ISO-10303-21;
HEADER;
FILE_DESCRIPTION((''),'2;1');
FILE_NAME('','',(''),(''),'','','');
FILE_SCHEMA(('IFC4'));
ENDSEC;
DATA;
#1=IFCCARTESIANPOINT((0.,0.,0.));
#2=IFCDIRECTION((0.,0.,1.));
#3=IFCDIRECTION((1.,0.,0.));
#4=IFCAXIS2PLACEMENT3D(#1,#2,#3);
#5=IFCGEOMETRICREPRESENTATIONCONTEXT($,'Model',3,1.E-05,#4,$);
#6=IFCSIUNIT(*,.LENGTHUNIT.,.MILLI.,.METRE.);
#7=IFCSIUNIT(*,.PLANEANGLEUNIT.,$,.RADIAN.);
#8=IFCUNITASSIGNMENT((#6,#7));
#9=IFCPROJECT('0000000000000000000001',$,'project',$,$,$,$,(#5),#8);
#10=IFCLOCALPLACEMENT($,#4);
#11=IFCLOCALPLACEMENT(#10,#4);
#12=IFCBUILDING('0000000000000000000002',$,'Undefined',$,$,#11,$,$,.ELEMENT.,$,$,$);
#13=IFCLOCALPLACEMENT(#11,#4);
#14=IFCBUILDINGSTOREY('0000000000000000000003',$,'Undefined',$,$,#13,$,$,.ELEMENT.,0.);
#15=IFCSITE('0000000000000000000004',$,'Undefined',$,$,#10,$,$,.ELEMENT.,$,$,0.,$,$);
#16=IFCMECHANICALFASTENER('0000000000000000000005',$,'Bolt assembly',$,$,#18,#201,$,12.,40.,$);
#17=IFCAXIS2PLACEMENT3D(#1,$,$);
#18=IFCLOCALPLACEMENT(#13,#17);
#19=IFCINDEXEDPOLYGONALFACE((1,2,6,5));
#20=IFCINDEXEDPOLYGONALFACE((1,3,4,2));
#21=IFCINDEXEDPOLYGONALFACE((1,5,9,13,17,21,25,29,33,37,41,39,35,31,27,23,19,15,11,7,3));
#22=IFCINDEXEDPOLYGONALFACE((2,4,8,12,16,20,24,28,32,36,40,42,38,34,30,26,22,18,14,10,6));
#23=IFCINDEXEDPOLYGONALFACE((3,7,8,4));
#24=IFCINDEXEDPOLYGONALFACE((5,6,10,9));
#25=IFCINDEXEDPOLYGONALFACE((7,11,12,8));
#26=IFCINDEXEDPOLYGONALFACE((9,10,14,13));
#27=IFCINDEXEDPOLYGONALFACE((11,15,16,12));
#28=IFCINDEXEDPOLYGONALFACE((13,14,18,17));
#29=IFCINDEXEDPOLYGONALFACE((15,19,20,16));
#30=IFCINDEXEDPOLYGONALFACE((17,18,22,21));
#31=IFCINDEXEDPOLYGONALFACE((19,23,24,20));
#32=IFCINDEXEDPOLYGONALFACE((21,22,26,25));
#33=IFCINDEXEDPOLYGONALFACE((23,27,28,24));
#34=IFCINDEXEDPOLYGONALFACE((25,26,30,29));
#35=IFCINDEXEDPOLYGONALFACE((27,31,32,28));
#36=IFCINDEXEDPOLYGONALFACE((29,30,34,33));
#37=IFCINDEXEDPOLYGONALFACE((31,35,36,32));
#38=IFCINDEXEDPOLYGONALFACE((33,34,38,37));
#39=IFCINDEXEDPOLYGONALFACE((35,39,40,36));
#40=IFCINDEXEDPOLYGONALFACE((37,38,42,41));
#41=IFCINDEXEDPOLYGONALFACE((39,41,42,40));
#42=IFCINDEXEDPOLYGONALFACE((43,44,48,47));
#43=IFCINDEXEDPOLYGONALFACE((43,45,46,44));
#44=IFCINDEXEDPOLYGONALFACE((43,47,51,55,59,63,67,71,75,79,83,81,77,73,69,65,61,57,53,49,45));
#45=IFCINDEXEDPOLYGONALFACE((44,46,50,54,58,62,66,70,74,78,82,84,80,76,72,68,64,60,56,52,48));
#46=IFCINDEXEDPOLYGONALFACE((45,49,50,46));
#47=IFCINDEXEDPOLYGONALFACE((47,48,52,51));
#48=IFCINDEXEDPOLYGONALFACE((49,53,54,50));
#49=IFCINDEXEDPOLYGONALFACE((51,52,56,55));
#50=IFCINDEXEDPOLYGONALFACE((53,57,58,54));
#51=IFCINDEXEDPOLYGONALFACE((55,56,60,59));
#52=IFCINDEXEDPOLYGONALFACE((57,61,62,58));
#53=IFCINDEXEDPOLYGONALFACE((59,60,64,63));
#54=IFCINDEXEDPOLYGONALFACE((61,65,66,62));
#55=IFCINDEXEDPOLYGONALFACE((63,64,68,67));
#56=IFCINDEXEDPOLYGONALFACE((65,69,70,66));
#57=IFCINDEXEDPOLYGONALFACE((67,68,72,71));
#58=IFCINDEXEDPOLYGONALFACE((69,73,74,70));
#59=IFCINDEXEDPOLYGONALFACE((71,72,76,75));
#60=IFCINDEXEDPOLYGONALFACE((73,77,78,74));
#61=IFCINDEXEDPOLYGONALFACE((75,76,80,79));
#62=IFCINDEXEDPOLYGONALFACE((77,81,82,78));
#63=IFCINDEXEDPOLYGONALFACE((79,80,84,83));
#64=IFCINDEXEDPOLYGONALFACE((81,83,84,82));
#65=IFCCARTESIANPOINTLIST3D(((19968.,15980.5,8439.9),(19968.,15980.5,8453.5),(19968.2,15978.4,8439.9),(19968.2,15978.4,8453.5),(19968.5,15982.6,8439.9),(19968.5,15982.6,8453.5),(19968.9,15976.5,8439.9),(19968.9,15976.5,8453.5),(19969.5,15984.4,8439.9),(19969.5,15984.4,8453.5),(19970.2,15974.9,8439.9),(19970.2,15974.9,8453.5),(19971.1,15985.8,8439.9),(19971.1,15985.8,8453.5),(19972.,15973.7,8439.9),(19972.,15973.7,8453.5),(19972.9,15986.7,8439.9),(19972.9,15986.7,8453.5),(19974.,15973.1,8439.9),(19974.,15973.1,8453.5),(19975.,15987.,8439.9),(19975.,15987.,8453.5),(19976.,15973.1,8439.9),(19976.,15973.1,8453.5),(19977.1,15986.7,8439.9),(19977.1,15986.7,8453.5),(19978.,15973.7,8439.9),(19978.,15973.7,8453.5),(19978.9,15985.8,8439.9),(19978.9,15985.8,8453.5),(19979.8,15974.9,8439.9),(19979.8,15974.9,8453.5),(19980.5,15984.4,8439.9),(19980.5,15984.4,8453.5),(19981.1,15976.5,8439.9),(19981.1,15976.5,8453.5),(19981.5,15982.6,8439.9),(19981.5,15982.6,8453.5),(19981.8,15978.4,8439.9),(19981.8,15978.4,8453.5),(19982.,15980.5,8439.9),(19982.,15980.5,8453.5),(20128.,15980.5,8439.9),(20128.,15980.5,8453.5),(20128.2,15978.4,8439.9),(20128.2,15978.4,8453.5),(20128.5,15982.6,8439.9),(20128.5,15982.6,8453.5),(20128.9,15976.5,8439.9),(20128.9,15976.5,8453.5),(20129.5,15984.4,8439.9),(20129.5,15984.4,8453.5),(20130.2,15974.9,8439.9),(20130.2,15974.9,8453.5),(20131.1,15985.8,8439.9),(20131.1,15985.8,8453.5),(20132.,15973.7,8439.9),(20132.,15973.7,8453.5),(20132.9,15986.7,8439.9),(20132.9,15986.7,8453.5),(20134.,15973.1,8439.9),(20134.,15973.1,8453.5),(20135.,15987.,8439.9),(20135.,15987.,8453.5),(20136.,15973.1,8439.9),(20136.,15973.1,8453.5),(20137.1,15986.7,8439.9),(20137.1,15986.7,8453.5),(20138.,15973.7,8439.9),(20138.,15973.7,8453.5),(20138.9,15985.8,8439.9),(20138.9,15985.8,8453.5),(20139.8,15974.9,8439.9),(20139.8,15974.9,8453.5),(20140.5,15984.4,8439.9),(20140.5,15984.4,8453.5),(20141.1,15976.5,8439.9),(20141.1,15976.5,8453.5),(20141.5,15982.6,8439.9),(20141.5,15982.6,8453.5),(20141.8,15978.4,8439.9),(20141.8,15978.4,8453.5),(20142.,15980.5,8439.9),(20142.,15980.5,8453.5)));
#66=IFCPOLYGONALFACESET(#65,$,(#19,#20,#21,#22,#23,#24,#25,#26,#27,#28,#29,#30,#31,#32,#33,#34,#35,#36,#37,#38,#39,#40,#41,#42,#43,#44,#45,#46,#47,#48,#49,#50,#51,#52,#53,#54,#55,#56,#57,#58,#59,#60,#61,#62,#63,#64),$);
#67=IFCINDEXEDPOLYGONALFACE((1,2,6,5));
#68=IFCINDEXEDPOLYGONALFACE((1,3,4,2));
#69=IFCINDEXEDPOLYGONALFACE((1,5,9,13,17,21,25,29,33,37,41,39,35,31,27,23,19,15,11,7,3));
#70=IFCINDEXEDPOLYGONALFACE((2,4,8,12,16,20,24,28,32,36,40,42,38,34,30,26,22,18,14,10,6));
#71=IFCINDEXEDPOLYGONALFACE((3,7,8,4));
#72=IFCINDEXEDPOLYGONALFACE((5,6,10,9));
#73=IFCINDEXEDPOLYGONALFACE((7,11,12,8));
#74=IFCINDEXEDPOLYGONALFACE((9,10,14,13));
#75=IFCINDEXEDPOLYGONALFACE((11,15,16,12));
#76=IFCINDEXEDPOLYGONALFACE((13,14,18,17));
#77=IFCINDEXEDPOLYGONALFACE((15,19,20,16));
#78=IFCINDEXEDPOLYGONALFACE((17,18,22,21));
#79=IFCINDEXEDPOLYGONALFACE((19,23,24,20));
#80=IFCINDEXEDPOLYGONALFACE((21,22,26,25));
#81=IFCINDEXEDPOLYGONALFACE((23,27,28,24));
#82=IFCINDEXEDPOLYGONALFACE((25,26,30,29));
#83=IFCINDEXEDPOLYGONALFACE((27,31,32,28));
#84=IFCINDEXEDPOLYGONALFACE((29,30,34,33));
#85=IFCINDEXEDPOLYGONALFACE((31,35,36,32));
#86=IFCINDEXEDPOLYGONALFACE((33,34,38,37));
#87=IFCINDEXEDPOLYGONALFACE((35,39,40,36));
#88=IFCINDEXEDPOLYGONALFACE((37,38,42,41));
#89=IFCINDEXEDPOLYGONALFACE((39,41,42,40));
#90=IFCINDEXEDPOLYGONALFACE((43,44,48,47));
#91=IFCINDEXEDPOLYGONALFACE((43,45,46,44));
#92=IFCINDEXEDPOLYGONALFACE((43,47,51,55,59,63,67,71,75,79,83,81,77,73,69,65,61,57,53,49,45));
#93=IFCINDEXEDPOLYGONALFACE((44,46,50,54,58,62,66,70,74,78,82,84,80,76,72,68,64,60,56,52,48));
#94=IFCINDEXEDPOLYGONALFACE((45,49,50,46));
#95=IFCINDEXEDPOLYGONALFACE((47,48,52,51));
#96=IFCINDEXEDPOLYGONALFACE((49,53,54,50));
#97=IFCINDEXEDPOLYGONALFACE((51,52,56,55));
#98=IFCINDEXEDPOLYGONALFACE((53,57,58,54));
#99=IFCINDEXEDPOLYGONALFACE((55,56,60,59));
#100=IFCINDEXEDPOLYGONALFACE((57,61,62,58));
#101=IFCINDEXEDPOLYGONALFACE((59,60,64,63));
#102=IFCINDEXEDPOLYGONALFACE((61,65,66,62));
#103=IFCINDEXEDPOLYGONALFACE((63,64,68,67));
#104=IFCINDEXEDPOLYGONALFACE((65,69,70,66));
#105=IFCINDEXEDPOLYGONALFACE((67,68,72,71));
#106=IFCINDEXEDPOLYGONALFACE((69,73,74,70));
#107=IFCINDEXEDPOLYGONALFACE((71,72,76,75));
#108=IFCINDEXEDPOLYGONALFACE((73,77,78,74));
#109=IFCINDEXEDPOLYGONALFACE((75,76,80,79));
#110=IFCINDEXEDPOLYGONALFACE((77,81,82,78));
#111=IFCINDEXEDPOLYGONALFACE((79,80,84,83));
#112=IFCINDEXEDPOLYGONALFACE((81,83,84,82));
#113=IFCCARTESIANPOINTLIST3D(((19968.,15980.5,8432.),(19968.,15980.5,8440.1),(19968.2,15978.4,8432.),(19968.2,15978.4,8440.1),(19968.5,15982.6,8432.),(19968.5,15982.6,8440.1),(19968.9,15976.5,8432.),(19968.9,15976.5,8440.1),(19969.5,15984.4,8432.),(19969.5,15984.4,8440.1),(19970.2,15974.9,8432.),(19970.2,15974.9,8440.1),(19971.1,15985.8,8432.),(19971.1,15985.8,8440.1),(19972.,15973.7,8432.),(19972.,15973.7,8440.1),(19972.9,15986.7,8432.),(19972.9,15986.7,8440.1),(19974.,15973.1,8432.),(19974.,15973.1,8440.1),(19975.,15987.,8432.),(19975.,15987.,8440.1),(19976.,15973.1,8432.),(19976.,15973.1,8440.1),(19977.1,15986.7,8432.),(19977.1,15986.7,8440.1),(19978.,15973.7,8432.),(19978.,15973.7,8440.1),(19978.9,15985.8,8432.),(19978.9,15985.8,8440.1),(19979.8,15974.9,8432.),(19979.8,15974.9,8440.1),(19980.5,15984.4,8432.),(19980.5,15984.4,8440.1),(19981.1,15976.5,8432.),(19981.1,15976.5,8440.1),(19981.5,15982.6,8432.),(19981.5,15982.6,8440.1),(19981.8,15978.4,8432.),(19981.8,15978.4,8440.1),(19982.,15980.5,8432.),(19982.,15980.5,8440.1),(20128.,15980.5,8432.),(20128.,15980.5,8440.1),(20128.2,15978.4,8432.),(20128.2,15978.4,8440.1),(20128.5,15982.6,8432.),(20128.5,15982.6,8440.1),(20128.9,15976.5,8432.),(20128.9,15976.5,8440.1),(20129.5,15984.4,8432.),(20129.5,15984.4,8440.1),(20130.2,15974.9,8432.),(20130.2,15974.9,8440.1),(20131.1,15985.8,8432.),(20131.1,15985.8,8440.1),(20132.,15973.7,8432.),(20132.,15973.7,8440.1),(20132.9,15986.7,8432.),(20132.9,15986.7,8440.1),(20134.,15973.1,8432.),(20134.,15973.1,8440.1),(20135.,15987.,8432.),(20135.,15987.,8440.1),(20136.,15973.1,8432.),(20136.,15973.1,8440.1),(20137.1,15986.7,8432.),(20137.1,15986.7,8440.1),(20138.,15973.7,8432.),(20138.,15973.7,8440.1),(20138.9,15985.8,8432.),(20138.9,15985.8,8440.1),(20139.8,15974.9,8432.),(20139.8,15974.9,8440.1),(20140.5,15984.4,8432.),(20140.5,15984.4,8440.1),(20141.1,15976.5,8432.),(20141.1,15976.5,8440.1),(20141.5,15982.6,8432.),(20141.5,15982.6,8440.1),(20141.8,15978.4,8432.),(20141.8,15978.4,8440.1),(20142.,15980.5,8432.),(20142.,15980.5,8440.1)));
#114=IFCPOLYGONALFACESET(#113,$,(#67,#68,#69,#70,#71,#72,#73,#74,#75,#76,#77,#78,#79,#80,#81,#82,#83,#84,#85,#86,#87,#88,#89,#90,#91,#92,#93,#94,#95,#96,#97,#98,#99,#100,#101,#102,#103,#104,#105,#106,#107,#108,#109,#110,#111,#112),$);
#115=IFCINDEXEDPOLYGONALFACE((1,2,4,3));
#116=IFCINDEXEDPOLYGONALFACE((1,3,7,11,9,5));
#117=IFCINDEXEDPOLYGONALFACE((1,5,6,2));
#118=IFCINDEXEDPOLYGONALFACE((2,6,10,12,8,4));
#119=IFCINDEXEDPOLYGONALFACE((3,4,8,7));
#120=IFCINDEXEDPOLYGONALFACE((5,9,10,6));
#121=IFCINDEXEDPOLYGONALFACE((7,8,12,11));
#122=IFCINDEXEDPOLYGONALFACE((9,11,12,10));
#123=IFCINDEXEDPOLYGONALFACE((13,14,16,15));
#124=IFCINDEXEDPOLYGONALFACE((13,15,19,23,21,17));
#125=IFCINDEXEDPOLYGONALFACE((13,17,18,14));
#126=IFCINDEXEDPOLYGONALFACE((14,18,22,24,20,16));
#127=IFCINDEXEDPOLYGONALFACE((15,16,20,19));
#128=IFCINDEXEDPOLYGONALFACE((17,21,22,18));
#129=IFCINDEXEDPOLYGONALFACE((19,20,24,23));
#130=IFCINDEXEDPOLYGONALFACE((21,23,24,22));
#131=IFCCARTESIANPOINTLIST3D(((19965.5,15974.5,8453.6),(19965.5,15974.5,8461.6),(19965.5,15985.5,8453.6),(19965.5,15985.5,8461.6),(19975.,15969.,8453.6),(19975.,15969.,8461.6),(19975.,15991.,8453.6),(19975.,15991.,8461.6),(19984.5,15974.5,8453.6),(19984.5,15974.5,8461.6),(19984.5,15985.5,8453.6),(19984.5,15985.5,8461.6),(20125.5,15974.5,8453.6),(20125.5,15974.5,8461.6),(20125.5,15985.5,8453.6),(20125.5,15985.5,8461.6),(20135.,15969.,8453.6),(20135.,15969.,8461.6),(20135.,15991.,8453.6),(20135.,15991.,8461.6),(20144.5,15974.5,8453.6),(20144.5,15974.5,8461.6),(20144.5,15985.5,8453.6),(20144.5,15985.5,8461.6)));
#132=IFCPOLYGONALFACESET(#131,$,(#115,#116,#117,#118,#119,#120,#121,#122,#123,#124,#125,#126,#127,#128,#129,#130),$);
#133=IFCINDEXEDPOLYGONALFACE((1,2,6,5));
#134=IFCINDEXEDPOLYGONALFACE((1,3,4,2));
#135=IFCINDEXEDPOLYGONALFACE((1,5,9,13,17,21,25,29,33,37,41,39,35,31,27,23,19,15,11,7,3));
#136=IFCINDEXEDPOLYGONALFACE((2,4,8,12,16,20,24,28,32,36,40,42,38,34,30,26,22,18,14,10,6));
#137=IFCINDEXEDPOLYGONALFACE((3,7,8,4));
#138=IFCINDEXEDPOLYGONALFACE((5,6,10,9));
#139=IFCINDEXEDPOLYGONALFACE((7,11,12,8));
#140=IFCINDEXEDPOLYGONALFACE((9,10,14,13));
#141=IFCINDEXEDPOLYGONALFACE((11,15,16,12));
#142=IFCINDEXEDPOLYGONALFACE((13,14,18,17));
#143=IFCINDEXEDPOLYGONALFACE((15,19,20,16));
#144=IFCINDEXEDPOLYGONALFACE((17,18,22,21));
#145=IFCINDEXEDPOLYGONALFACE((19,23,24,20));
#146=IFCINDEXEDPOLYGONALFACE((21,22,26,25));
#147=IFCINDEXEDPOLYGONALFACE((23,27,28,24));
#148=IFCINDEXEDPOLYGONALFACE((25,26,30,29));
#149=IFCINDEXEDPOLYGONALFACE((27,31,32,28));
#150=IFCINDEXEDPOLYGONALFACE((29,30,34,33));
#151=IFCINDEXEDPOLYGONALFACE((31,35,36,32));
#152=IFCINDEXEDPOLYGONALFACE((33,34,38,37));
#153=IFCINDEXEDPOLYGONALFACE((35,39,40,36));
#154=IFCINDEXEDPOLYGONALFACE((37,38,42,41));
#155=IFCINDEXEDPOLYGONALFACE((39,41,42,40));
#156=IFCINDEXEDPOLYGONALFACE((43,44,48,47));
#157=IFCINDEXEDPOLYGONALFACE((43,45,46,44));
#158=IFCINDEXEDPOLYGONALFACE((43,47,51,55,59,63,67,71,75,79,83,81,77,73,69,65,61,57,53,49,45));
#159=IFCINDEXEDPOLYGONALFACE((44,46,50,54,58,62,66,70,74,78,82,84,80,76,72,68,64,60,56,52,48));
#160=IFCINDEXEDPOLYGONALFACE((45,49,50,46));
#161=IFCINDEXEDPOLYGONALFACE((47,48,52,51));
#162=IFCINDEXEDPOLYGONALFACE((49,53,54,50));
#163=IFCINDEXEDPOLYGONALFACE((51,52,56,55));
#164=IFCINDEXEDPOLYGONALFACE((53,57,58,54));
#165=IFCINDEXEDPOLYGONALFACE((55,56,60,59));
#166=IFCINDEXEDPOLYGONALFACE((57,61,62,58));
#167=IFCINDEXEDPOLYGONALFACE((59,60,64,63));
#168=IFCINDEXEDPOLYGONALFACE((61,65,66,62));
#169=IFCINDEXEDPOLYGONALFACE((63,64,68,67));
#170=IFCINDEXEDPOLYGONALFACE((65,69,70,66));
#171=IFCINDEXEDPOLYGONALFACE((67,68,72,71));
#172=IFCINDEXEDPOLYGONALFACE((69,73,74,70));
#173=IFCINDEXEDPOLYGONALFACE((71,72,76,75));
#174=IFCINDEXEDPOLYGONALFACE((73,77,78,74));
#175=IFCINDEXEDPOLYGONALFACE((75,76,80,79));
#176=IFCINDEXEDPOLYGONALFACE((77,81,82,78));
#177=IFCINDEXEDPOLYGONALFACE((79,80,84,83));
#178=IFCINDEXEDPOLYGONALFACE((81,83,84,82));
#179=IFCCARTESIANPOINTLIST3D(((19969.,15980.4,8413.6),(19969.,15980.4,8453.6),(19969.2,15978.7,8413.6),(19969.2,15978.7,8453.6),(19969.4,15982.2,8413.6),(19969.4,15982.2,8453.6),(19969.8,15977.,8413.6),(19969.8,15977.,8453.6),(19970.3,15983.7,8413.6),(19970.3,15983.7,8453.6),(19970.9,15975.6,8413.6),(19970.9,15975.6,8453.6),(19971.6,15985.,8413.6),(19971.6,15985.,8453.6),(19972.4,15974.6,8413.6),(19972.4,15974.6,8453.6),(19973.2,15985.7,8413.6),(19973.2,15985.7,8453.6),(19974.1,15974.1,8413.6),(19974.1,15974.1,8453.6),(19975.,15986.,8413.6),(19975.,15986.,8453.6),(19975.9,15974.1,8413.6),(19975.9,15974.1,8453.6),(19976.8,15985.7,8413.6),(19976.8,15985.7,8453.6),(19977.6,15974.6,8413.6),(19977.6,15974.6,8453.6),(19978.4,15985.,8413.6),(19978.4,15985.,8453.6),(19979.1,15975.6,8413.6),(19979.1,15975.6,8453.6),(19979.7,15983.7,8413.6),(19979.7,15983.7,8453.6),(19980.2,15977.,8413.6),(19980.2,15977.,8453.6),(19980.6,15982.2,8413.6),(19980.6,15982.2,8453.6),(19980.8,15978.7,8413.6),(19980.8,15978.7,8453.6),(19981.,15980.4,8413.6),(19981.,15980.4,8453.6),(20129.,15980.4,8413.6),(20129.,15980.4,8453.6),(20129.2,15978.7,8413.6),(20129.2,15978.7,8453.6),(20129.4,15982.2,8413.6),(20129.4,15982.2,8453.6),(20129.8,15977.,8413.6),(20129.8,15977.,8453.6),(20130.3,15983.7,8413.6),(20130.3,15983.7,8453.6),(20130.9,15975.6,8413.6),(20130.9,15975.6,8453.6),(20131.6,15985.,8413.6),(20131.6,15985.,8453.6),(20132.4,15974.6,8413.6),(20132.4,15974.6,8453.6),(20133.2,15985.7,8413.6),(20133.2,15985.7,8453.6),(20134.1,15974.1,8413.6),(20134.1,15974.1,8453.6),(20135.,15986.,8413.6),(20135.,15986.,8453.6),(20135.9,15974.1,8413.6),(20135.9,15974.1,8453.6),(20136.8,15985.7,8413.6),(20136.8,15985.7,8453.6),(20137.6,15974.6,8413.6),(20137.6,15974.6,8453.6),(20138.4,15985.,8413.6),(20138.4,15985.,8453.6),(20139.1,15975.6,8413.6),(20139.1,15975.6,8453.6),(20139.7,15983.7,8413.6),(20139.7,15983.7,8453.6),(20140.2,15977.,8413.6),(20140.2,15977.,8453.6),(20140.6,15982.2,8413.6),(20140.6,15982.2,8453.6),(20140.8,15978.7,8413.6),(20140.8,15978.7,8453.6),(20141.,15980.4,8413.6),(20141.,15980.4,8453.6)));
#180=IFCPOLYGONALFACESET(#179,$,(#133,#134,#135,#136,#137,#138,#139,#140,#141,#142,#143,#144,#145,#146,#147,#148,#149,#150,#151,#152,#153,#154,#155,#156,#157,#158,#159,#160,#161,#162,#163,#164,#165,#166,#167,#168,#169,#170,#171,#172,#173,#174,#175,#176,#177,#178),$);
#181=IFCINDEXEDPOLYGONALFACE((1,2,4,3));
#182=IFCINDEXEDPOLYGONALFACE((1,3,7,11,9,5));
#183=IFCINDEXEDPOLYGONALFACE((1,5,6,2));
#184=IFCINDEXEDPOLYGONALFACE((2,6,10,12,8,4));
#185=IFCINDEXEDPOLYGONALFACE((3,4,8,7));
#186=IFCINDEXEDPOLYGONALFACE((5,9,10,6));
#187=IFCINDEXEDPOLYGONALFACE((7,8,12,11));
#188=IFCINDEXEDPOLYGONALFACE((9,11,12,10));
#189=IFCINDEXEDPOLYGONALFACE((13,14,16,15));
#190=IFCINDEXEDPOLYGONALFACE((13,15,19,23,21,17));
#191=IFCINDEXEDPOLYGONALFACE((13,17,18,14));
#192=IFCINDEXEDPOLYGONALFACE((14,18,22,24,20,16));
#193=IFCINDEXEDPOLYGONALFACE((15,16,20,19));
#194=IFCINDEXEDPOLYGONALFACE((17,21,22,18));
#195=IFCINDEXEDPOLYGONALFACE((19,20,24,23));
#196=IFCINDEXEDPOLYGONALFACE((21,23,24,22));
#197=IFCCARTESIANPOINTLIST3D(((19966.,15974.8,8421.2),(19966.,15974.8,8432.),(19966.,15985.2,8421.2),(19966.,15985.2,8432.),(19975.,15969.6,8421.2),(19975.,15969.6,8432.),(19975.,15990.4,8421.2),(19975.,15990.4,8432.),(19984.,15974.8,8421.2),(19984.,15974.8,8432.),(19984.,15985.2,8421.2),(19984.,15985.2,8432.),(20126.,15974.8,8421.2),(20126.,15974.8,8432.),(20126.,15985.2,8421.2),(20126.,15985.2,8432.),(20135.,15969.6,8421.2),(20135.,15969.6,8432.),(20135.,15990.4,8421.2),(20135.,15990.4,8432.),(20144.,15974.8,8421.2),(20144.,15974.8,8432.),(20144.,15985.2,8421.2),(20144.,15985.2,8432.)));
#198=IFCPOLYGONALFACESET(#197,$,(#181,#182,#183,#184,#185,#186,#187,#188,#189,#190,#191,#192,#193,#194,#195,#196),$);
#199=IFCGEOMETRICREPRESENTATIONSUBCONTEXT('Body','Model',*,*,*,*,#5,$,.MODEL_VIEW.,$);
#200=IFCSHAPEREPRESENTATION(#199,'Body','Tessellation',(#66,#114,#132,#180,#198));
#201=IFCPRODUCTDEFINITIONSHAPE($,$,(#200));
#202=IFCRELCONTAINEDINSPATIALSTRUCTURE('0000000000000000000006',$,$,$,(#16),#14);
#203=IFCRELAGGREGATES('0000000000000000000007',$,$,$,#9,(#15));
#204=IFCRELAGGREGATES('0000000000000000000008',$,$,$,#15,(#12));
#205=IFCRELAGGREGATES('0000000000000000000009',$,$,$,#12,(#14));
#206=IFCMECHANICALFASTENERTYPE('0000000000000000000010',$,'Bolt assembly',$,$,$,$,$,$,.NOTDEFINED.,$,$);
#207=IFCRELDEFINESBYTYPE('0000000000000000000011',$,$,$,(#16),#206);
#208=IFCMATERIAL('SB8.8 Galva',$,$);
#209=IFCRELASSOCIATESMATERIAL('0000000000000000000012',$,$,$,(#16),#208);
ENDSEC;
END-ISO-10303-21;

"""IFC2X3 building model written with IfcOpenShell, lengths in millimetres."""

from ifc_helpers import new_model, si_unit, frame, origin_with_axes, origin_2d_with_axis, place, context, subcontext, project, spatial, polyline, circle, outline, extrude, source, transform, mapped, material, type_object, element, save


model = new_model("IFC2X3")

# Units and contexts
model_context = context("Model", 3, precision=1e-05, world=origin_with_axes())
body_context = subcontext(model_context, "Body", "Model", "MODEL_VIEW")
ifc_project = project(units=[si_unit("LENGTHUNIT", "METRE", prefix="MILLI"), si_unit("PLANEANGLEUNIT", "RADIAN")], contexts=[model_context])

# Site, building, storey
site_placement = place(None, origin_with_axes())
site = spatial("IfcSite", under=ifc_project, at=site_placement, Name="Undefined", CompositionType="ELEMENT", RefElevation=0.0)
building_placement = place(site_placement, origin_with_axes())
building = spatial("IfcBuilding", under=site, at=building_placement, Name="Undefined", CompositionType="ELEMENT")
storey_placement = place(building_placement, origin_with_axes())
storey = spatial("IfcBuildingStorey", under=building, at=storey_placement, Name="Undefined", CompositionType="ELEMENT", Elevation=0.0)

# Mechanical fastener
mechanical_fastener_type = type_object("IfcMechanicalFastenerType", Name="Bolt assembly")
ifc_material_1 = material(Name="SB8.8 Galva")
shared_shape_1 = source(origin_with_axes(), body_context, "Body", "SweptSolid", [
    extrude(circle(Radius=7.0, at=origin_2d_with_axis()), frame((0.0, -13.5, 0.0), z_axis=(0.0, 1.0, 0.0), x_axis=(1.0, 0.0, 0.0)), (0.0, 0.0, 1.0), 13.6),
    extrude(circle(Radius=7.0, at=origin_2d_with_axis()), frame((0.0, -0.1, 0.0), z_axis=(0.0, 1.0, 0.0), x_axis=(1.0, 0.0, 0.0)), (0.0, 0.0, 1.0), 8.1),
    extrude(outline(polyline([(11.0, 0.0), (5.5, 9.5), (-5.5, 9.5), (-11.0, 0.0), (-5.5, -9.5), (5.5, -9.5), (11.0, 0.0)])), frame((0.0, -21.6, 0.0), z_axis=(0.0, 1.0, 0.0), x_axis=(1.0, 0.0, 0.0)), (0.0, 0.0, 1.0), 8.0),
    extrude(circle(Radius=6.0, at=origin_2d_with_axis()), frame((0.0, -13.6, 0.0), z_axis=(0.0, 1.0, 0.0), x_axis=(1.0, 0.0, 0.0)), (0.0, 0.0, 1.0), 40.0),
    extrude(outline(polyline([(10.4, 0.0), (5.2, 9.0), (-5.2, 9.0), (-10.4, 0.0), (-5.2, -9.0), (5.2, -9.0), (10.4, 0.0)])), frame((0.0, 8.0, 0.0), z_axis=(0.0, 1.0, 0.0), x_axis=(1.0, 0.0, 0.0)), (0.0, 0.0, 1.0), 10.8),
])
for number, where, z_axis, x_axis, name in (
    (1, (20055.0, 15980.0, 8440.0), (-1.0, 0.0, 0.0), (0.0, 1.0, 0.0), "Bolt assembly"),
):
    element("IfcMechanicalFastener", number, at=place(storey_placement, frame(where, z_axis=z_axis, x_axis=x_axis)), inside=storey, type_object=mechanical_fastener_type, material=ifc_material_1, Name=name, NominalDiameter=12.0, NominalLength=40.0, context=body_context, shape_type="MappedRepresentation", body=[
        mapped(shared_shape_1, transform((0.0, 0.0, -80.0))),
        mapped(shared_shape_1, transform((0.0, 0.0, 80.0))),
    ])

save(model, "model.ifc")
